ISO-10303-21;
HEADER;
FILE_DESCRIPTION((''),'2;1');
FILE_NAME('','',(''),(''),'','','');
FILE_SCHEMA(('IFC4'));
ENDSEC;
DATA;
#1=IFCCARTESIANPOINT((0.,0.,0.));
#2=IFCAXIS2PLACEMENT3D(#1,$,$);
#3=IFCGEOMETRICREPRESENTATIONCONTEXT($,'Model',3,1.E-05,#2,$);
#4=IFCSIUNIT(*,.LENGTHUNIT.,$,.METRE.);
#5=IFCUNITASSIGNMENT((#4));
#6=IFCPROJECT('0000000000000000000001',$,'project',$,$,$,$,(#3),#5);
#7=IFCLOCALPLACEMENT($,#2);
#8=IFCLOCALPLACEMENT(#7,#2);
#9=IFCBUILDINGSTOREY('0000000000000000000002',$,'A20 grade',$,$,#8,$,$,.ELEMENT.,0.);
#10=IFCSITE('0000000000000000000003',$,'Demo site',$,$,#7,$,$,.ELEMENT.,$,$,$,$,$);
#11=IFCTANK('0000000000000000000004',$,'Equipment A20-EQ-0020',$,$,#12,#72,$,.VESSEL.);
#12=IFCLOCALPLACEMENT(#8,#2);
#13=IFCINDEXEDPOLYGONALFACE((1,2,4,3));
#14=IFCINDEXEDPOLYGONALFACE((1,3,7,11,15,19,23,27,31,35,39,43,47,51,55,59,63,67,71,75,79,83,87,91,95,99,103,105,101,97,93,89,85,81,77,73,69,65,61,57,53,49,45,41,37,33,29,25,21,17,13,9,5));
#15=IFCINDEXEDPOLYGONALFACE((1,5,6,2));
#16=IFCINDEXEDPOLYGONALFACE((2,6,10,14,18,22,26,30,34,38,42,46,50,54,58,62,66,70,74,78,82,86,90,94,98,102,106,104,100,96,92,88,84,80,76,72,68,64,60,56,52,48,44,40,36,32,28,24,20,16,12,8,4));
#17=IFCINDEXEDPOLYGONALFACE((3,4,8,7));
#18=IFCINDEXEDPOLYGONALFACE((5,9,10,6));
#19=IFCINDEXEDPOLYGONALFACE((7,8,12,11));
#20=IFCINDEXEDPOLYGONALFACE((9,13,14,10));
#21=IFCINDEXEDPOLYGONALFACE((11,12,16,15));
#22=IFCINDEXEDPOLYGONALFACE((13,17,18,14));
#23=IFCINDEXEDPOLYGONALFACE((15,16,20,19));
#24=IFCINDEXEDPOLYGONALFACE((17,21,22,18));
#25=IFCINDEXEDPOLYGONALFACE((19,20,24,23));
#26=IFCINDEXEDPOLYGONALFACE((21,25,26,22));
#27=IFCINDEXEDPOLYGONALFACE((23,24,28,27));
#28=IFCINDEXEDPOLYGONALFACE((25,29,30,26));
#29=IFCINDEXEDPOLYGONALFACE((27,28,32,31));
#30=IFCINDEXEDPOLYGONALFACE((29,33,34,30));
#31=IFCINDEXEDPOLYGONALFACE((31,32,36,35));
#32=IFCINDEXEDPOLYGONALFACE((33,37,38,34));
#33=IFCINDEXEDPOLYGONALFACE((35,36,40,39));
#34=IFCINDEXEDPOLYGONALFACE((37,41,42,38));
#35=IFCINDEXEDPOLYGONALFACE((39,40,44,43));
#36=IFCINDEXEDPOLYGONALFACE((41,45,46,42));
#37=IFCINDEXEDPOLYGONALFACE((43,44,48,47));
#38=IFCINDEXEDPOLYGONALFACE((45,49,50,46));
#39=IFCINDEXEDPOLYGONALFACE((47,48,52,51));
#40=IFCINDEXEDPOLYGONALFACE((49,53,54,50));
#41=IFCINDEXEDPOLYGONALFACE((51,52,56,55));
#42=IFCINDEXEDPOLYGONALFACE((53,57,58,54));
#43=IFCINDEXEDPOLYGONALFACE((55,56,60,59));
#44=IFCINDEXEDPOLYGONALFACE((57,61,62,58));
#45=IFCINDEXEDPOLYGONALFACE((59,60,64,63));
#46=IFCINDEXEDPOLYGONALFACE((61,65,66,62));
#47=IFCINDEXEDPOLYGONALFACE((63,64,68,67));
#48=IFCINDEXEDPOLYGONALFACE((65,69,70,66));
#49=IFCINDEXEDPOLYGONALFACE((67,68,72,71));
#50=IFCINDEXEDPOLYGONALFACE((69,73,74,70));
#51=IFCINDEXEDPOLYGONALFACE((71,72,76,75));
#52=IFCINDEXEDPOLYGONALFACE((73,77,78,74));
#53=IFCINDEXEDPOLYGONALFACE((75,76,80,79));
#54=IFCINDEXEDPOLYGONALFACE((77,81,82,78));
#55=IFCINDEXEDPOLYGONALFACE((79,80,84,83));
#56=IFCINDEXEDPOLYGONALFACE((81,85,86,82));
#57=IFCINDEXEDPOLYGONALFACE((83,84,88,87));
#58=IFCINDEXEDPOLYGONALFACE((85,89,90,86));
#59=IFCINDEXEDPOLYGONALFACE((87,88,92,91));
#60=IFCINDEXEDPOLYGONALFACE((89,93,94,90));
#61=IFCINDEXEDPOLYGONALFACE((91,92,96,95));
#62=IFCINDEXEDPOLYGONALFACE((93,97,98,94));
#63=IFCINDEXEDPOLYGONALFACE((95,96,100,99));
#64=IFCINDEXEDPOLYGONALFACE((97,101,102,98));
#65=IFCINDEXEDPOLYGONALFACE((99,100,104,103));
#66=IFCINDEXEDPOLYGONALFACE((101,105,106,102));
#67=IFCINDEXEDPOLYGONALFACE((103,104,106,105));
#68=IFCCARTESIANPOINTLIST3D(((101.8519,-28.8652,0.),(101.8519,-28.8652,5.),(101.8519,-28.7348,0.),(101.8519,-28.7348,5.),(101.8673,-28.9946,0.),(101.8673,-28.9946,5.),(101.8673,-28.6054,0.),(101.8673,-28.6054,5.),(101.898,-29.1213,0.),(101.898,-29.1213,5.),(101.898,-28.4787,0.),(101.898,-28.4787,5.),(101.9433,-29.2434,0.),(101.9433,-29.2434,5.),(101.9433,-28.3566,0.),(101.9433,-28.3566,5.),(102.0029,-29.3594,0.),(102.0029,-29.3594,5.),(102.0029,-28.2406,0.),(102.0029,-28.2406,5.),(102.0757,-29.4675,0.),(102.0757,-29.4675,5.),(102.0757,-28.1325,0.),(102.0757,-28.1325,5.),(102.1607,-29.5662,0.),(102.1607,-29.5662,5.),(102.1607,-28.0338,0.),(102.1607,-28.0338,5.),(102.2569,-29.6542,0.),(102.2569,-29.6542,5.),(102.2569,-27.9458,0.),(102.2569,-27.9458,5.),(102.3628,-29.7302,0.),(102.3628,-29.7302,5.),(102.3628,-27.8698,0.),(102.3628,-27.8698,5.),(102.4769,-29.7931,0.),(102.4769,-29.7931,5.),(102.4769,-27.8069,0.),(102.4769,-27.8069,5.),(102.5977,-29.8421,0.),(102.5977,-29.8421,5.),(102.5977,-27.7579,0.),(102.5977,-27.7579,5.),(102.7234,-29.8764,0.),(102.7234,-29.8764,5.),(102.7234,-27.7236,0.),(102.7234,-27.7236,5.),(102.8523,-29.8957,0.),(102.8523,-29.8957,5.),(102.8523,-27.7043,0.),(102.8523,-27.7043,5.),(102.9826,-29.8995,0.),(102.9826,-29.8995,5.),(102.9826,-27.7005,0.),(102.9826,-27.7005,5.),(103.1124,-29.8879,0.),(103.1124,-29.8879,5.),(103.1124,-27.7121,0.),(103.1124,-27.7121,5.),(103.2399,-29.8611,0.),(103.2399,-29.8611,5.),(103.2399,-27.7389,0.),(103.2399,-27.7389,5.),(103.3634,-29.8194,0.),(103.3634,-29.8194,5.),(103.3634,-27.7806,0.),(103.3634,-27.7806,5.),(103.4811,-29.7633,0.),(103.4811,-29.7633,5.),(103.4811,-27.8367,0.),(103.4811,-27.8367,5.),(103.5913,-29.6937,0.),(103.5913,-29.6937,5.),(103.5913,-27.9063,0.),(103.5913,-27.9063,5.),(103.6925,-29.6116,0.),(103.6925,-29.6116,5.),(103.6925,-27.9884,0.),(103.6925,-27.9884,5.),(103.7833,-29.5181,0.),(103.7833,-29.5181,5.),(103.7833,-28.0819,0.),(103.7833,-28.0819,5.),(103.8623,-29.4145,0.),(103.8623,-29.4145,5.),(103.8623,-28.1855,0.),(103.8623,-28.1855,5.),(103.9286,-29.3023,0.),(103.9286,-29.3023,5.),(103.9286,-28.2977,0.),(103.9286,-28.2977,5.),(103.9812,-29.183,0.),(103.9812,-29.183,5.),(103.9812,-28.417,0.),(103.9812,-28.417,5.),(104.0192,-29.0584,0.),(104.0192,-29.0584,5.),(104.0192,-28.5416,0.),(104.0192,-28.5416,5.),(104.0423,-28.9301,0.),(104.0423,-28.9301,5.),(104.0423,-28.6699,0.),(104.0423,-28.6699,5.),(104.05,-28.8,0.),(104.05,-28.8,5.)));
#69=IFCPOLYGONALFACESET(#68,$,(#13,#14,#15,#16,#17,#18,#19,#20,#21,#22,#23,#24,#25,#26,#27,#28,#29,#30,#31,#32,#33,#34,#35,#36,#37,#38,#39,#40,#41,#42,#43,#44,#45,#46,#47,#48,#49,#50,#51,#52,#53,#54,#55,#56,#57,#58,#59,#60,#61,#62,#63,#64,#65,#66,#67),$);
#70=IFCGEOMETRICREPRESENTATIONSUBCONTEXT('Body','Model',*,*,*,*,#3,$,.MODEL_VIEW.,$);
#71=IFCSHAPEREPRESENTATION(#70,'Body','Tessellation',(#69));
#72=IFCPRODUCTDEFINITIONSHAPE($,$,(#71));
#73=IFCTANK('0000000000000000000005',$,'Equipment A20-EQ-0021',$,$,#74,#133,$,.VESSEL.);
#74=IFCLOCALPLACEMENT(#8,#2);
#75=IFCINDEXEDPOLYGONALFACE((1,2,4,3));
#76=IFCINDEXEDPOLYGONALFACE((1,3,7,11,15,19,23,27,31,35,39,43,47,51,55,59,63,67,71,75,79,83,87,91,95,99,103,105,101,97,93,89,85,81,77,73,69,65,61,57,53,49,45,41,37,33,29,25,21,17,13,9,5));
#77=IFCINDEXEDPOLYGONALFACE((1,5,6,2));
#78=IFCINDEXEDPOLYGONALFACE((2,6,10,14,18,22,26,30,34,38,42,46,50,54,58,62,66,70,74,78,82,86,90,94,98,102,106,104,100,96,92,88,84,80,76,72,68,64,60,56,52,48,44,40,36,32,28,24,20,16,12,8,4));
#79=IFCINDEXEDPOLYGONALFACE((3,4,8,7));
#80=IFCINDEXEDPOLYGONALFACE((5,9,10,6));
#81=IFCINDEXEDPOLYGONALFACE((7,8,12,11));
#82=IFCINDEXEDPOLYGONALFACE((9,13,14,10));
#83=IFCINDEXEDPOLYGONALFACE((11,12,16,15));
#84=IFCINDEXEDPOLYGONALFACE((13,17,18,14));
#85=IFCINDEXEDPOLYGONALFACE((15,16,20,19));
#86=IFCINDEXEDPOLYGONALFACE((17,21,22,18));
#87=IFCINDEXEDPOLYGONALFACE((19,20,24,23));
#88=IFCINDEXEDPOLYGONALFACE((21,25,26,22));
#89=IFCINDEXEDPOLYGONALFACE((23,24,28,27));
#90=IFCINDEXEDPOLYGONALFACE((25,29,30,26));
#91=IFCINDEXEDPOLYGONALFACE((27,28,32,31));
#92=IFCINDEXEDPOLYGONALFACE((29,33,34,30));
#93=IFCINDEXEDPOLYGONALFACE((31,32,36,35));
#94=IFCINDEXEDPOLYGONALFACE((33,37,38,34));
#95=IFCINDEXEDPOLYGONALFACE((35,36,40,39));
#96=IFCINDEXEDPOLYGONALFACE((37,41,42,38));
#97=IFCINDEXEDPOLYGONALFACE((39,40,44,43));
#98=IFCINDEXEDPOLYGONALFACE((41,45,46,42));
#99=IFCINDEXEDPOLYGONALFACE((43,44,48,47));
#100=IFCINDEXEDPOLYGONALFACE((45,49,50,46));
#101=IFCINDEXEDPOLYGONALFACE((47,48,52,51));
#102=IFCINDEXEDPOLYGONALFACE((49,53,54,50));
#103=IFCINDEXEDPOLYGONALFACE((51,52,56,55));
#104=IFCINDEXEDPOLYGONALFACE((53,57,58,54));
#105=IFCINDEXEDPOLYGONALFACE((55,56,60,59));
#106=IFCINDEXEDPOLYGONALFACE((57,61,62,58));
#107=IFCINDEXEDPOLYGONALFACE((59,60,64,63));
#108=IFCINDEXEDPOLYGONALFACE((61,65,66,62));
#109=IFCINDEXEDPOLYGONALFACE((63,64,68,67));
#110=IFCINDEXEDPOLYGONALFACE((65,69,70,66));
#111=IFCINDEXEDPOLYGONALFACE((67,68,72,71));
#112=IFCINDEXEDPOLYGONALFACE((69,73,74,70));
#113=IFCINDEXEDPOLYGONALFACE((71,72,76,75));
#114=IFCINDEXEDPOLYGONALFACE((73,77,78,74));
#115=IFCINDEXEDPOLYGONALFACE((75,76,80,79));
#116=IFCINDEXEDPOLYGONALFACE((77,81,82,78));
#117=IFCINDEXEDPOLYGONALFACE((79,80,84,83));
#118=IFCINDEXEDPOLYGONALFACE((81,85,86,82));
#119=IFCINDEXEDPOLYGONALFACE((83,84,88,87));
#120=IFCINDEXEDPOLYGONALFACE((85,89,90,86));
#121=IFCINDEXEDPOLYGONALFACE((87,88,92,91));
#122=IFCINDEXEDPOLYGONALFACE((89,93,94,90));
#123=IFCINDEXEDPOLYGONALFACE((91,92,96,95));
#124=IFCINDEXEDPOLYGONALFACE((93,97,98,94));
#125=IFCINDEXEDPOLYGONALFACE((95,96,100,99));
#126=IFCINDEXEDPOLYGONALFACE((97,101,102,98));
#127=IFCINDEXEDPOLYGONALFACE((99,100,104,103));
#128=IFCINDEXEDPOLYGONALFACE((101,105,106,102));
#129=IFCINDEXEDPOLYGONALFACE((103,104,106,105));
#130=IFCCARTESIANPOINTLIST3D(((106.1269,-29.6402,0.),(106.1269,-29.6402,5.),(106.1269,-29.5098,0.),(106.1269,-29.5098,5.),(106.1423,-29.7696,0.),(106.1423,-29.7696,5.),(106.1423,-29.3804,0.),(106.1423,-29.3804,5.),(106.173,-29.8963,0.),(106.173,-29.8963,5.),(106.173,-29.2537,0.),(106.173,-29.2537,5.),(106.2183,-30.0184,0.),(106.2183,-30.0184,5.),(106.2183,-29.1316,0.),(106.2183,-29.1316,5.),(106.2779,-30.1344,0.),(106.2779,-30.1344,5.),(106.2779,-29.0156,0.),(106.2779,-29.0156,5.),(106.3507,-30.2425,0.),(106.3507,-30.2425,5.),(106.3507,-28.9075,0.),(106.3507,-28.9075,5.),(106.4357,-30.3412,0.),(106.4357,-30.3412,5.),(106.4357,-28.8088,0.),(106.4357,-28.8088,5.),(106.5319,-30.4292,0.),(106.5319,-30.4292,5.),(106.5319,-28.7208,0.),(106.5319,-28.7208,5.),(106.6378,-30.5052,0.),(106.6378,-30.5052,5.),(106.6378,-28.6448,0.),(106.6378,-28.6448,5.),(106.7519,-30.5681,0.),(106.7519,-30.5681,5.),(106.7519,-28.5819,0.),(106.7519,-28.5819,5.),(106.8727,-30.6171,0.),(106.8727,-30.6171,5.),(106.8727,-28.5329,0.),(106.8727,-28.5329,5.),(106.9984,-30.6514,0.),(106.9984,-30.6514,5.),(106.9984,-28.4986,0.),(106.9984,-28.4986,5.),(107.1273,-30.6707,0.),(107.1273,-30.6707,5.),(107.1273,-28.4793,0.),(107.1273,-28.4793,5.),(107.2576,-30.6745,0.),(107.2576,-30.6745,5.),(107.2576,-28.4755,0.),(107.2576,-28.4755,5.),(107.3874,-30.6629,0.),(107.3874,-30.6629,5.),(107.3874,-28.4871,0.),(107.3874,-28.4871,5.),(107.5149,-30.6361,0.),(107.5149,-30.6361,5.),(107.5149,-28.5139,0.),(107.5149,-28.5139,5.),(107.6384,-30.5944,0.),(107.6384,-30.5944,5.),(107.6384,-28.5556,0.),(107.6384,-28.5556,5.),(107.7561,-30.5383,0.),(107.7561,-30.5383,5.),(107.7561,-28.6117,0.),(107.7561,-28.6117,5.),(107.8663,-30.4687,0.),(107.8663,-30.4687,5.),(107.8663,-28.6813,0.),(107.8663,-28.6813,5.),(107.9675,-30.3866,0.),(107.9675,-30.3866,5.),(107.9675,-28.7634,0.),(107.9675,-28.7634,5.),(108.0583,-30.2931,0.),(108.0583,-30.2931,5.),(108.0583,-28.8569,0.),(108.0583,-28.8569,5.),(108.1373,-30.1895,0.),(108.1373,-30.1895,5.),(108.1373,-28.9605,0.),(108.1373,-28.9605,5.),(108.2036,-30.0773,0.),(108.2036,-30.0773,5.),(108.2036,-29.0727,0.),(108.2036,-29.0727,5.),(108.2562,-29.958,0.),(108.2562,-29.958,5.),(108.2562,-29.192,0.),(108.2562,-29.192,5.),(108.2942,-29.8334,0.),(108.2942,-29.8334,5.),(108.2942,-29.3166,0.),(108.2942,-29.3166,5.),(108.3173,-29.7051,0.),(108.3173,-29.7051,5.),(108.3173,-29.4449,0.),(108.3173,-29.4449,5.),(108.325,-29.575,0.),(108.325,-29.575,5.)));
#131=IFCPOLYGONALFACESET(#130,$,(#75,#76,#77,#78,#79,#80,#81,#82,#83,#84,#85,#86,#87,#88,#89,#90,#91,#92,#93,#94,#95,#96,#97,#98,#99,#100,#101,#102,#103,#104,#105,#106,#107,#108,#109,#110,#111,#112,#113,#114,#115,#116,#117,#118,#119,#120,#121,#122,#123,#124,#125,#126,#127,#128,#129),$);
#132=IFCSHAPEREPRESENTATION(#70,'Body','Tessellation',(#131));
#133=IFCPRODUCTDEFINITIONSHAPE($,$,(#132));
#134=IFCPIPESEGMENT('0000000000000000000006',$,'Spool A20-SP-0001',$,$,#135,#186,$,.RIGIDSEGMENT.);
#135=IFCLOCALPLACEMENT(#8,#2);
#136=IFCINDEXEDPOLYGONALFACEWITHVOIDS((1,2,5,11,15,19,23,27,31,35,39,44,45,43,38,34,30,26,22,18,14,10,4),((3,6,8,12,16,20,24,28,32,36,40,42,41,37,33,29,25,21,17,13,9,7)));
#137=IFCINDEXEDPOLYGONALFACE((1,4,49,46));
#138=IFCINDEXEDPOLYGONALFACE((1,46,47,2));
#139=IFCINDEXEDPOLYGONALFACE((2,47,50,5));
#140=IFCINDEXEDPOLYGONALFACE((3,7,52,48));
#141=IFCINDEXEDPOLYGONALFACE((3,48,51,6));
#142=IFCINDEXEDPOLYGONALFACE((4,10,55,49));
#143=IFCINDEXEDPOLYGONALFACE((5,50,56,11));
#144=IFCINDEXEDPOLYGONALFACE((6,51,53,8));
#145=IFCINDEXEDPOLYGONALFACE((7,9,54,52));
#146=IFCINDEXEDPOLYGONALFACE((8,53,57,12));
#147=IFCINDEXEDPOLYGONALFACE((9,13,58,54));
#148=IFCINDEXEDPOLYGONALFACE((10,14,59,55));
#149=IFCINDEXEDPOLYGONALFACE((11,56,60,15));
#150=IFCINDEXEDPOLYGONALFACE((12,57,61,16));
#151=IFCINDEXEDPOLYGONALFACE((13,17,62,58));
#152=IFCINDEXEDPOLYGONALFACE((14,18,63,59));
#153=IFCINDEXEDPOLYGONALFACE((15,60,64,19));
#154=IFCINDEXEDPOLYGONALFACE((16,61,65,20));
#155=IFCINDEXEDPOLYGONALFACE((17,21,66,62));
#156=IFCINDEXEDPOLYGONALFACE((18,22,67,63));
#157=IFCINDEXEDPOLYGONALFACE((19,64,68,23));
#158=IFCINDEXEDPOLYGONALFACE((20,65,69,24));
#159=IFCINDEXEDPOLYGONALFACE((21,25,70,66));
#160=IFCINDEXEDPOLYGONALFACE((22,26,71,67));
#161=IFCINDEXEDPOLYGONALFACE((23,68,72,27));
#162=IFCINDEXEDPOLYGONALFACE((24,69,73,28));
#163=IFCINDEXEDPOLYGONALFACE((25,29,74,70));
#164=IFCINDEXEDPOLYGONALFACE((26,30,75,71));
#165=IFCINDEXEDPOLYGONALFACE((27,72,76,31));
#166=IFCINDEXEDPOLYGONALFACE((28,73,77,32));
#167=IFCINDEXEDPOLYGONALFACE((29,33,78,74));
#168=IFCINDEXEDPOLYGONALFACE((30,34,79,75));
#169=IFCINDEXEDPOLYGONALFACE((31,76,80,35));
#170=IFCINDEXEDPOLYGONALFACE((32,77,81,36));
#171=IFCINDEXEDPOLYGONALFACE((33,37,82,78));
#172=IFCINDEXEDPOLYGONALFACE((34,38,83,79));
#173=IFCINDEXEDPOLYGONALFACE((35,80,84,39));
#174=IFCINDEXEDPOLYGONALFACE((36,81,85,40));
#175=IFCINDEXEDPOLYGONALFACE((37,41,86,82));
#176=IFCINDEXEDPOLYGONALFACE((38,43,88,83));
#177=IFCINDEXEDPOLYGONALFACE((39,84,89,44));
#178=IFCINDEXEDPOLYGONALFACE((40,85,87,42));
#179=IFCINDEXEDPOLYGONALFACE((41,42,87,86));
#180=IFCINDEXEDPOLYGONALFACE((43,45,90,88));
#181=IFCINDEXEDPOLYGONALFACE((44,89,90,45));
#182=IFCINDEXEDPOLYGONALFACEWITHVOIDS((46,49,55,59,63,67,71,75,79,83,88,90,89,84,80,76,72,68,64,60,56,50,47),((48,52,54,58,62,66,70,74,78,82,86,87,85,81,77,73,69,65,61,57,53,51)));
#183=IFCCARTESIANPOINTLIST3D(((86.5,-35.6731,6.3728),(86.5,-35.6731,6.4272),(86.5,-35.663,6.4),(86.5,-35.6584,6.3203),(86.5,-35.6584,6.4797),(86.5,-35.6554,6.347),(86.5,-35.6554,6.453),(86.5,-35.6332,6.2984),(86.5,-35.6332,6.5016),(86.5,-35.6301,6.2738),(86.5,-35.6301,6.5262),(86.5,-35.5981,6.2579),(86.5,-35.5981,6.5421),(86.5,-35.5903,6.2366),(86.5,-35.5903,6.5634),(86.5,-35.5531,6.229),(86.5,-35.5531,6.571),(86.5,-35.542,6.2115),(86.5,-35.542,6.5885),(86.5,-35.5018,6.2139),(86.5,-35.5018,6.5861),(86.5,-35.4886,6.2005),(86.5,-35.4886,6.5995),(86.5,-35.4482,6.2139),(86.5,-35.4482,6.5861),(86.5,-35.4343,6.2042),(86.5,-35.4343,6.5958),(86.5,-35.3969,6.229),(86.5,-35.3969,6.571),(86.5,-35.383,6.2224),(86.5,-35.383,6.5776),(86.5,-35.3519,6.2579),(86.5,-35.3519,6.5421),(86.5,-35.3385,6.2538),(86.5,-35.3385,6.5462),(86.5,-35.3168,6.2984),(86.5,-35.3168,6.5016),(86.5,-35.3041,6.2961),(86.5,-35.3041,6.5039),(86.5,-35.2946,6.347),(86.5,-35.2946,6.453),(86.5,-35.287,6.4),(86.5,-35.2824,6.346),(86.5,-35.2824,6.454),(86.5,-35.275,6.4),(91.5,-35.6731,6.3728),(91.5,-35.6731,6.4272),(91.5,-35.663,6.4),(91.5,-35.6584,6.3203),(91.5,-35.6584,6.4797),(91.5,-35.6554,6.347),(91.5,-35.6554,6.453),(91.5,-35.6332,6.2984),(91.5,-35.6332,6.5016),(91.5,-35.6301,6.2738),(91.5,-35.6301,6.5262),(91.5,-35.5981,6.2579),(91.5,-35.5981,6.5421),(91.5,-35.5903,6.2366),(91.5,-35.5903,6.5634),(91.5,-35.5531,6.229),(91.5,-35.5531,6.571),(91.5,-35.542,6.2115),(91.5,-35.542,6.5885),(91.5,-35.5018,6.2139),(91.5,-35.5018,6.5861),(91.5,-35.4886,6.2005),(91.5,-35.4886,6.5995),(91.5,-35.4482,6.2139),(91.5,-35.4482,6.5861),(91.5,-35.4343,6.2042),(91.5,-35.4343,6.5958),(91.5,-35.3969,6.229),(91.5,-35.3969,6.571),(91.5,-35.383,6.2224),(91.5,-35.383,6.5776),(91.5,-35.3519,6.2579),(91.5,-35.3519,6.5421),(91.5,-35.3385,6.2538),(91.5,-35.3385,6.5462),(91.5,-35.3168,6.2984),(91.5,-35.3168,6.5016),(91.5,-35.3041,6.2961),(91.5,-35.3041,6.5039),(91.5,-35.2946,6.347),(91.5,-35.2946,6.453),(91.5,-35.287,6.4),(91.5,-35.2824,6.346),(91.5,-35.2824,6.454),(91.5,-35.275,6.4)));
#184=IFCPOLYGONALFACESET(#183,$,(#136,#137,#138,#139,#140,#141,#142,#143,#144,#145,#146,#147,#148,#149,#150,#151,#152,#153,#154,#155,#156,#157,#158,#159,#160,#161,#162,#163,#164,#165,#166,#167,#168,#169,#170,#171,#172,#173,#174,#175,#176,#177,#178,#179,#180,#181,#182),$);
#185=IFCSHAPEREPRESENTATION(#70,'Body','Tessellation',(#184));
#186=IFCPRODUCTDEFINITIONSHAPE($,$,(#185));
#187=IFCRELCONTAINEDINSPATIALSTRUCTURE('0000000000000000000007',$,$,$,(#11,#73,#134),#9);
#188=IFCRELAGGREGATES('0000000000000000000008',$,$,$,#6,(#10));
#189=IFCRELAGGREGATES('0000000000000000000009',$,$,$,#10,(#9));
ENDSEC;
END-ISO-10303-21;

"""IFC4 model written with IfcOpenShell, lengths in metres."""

from ifc_helpers import new_model, si_unit, frame, origin, place, context, subcontext, project, spatial, circle, hollow_circle, extrude, element, save


model = new_model("IFC4")

# Units and contexts
model_context = context("Model", 3, precision=1e-05, world=origin())
body_context = subcontext(model_context, "Body", "Model", "MODEL_VIEW")
ifc_project = project(units=[si_unit("LENGTHUNIT", "METRE")], contexts=[model_context])

# Site, storey
site_placement = place(None, origin())
site = spatial("IfcSite", under=ifc_project, at=site_placement, Name="Demo site", CompositionType="ELEMENT")
storey_placement = place(site_placement, origin())
storey = spatial("IfcBuildingStorey", under=site, at=storey_placement, Name="A20 grade", CompositionType="ELEMENT", Elevation=0.0)

# Tanks
for number, where, name in (
    (1, (102.95, -28.8, 0.0), "Equipment A20-EQ-0020"),
    (2, (107.225, -29.575, 0.0), "Equipment A20-EQ-0021"),
):
    element("IfcTank", number, at=place(storey_placement, frame(where)), inside=storey, Name=name, PredefinedType="VESSEL", context=body_context, shape_type="SweptSolid", body=[
        extrude(circle(Radius=1.1), origin(), (0.0, 0.0, 1.0), 5.0),
    ])

# Pipe segment
for number, where, name in (
    (3, (86.5, -35.475, 6.4), "Spool A20-SP-0001"),
):
    element("IfcPipeSegment", number, at=place(storey_placement, frame(where)), inside=storey, Name=name, PredefinedType="RIGIDSEGMENT", context=body_context, shape_type="SweptSolid", body=[
        extrude(hollow_circle(Radius=0.2, WallThickness=0.012), frame((0.0, 0.0, 0.0), z_axis=(1.0, 0.0, 0.0), x_axis=(0.0, 1.0, 0.0)), (0.0, 0.0, 1.0), 5.0),
    ])

save(model, "model.ifc")
